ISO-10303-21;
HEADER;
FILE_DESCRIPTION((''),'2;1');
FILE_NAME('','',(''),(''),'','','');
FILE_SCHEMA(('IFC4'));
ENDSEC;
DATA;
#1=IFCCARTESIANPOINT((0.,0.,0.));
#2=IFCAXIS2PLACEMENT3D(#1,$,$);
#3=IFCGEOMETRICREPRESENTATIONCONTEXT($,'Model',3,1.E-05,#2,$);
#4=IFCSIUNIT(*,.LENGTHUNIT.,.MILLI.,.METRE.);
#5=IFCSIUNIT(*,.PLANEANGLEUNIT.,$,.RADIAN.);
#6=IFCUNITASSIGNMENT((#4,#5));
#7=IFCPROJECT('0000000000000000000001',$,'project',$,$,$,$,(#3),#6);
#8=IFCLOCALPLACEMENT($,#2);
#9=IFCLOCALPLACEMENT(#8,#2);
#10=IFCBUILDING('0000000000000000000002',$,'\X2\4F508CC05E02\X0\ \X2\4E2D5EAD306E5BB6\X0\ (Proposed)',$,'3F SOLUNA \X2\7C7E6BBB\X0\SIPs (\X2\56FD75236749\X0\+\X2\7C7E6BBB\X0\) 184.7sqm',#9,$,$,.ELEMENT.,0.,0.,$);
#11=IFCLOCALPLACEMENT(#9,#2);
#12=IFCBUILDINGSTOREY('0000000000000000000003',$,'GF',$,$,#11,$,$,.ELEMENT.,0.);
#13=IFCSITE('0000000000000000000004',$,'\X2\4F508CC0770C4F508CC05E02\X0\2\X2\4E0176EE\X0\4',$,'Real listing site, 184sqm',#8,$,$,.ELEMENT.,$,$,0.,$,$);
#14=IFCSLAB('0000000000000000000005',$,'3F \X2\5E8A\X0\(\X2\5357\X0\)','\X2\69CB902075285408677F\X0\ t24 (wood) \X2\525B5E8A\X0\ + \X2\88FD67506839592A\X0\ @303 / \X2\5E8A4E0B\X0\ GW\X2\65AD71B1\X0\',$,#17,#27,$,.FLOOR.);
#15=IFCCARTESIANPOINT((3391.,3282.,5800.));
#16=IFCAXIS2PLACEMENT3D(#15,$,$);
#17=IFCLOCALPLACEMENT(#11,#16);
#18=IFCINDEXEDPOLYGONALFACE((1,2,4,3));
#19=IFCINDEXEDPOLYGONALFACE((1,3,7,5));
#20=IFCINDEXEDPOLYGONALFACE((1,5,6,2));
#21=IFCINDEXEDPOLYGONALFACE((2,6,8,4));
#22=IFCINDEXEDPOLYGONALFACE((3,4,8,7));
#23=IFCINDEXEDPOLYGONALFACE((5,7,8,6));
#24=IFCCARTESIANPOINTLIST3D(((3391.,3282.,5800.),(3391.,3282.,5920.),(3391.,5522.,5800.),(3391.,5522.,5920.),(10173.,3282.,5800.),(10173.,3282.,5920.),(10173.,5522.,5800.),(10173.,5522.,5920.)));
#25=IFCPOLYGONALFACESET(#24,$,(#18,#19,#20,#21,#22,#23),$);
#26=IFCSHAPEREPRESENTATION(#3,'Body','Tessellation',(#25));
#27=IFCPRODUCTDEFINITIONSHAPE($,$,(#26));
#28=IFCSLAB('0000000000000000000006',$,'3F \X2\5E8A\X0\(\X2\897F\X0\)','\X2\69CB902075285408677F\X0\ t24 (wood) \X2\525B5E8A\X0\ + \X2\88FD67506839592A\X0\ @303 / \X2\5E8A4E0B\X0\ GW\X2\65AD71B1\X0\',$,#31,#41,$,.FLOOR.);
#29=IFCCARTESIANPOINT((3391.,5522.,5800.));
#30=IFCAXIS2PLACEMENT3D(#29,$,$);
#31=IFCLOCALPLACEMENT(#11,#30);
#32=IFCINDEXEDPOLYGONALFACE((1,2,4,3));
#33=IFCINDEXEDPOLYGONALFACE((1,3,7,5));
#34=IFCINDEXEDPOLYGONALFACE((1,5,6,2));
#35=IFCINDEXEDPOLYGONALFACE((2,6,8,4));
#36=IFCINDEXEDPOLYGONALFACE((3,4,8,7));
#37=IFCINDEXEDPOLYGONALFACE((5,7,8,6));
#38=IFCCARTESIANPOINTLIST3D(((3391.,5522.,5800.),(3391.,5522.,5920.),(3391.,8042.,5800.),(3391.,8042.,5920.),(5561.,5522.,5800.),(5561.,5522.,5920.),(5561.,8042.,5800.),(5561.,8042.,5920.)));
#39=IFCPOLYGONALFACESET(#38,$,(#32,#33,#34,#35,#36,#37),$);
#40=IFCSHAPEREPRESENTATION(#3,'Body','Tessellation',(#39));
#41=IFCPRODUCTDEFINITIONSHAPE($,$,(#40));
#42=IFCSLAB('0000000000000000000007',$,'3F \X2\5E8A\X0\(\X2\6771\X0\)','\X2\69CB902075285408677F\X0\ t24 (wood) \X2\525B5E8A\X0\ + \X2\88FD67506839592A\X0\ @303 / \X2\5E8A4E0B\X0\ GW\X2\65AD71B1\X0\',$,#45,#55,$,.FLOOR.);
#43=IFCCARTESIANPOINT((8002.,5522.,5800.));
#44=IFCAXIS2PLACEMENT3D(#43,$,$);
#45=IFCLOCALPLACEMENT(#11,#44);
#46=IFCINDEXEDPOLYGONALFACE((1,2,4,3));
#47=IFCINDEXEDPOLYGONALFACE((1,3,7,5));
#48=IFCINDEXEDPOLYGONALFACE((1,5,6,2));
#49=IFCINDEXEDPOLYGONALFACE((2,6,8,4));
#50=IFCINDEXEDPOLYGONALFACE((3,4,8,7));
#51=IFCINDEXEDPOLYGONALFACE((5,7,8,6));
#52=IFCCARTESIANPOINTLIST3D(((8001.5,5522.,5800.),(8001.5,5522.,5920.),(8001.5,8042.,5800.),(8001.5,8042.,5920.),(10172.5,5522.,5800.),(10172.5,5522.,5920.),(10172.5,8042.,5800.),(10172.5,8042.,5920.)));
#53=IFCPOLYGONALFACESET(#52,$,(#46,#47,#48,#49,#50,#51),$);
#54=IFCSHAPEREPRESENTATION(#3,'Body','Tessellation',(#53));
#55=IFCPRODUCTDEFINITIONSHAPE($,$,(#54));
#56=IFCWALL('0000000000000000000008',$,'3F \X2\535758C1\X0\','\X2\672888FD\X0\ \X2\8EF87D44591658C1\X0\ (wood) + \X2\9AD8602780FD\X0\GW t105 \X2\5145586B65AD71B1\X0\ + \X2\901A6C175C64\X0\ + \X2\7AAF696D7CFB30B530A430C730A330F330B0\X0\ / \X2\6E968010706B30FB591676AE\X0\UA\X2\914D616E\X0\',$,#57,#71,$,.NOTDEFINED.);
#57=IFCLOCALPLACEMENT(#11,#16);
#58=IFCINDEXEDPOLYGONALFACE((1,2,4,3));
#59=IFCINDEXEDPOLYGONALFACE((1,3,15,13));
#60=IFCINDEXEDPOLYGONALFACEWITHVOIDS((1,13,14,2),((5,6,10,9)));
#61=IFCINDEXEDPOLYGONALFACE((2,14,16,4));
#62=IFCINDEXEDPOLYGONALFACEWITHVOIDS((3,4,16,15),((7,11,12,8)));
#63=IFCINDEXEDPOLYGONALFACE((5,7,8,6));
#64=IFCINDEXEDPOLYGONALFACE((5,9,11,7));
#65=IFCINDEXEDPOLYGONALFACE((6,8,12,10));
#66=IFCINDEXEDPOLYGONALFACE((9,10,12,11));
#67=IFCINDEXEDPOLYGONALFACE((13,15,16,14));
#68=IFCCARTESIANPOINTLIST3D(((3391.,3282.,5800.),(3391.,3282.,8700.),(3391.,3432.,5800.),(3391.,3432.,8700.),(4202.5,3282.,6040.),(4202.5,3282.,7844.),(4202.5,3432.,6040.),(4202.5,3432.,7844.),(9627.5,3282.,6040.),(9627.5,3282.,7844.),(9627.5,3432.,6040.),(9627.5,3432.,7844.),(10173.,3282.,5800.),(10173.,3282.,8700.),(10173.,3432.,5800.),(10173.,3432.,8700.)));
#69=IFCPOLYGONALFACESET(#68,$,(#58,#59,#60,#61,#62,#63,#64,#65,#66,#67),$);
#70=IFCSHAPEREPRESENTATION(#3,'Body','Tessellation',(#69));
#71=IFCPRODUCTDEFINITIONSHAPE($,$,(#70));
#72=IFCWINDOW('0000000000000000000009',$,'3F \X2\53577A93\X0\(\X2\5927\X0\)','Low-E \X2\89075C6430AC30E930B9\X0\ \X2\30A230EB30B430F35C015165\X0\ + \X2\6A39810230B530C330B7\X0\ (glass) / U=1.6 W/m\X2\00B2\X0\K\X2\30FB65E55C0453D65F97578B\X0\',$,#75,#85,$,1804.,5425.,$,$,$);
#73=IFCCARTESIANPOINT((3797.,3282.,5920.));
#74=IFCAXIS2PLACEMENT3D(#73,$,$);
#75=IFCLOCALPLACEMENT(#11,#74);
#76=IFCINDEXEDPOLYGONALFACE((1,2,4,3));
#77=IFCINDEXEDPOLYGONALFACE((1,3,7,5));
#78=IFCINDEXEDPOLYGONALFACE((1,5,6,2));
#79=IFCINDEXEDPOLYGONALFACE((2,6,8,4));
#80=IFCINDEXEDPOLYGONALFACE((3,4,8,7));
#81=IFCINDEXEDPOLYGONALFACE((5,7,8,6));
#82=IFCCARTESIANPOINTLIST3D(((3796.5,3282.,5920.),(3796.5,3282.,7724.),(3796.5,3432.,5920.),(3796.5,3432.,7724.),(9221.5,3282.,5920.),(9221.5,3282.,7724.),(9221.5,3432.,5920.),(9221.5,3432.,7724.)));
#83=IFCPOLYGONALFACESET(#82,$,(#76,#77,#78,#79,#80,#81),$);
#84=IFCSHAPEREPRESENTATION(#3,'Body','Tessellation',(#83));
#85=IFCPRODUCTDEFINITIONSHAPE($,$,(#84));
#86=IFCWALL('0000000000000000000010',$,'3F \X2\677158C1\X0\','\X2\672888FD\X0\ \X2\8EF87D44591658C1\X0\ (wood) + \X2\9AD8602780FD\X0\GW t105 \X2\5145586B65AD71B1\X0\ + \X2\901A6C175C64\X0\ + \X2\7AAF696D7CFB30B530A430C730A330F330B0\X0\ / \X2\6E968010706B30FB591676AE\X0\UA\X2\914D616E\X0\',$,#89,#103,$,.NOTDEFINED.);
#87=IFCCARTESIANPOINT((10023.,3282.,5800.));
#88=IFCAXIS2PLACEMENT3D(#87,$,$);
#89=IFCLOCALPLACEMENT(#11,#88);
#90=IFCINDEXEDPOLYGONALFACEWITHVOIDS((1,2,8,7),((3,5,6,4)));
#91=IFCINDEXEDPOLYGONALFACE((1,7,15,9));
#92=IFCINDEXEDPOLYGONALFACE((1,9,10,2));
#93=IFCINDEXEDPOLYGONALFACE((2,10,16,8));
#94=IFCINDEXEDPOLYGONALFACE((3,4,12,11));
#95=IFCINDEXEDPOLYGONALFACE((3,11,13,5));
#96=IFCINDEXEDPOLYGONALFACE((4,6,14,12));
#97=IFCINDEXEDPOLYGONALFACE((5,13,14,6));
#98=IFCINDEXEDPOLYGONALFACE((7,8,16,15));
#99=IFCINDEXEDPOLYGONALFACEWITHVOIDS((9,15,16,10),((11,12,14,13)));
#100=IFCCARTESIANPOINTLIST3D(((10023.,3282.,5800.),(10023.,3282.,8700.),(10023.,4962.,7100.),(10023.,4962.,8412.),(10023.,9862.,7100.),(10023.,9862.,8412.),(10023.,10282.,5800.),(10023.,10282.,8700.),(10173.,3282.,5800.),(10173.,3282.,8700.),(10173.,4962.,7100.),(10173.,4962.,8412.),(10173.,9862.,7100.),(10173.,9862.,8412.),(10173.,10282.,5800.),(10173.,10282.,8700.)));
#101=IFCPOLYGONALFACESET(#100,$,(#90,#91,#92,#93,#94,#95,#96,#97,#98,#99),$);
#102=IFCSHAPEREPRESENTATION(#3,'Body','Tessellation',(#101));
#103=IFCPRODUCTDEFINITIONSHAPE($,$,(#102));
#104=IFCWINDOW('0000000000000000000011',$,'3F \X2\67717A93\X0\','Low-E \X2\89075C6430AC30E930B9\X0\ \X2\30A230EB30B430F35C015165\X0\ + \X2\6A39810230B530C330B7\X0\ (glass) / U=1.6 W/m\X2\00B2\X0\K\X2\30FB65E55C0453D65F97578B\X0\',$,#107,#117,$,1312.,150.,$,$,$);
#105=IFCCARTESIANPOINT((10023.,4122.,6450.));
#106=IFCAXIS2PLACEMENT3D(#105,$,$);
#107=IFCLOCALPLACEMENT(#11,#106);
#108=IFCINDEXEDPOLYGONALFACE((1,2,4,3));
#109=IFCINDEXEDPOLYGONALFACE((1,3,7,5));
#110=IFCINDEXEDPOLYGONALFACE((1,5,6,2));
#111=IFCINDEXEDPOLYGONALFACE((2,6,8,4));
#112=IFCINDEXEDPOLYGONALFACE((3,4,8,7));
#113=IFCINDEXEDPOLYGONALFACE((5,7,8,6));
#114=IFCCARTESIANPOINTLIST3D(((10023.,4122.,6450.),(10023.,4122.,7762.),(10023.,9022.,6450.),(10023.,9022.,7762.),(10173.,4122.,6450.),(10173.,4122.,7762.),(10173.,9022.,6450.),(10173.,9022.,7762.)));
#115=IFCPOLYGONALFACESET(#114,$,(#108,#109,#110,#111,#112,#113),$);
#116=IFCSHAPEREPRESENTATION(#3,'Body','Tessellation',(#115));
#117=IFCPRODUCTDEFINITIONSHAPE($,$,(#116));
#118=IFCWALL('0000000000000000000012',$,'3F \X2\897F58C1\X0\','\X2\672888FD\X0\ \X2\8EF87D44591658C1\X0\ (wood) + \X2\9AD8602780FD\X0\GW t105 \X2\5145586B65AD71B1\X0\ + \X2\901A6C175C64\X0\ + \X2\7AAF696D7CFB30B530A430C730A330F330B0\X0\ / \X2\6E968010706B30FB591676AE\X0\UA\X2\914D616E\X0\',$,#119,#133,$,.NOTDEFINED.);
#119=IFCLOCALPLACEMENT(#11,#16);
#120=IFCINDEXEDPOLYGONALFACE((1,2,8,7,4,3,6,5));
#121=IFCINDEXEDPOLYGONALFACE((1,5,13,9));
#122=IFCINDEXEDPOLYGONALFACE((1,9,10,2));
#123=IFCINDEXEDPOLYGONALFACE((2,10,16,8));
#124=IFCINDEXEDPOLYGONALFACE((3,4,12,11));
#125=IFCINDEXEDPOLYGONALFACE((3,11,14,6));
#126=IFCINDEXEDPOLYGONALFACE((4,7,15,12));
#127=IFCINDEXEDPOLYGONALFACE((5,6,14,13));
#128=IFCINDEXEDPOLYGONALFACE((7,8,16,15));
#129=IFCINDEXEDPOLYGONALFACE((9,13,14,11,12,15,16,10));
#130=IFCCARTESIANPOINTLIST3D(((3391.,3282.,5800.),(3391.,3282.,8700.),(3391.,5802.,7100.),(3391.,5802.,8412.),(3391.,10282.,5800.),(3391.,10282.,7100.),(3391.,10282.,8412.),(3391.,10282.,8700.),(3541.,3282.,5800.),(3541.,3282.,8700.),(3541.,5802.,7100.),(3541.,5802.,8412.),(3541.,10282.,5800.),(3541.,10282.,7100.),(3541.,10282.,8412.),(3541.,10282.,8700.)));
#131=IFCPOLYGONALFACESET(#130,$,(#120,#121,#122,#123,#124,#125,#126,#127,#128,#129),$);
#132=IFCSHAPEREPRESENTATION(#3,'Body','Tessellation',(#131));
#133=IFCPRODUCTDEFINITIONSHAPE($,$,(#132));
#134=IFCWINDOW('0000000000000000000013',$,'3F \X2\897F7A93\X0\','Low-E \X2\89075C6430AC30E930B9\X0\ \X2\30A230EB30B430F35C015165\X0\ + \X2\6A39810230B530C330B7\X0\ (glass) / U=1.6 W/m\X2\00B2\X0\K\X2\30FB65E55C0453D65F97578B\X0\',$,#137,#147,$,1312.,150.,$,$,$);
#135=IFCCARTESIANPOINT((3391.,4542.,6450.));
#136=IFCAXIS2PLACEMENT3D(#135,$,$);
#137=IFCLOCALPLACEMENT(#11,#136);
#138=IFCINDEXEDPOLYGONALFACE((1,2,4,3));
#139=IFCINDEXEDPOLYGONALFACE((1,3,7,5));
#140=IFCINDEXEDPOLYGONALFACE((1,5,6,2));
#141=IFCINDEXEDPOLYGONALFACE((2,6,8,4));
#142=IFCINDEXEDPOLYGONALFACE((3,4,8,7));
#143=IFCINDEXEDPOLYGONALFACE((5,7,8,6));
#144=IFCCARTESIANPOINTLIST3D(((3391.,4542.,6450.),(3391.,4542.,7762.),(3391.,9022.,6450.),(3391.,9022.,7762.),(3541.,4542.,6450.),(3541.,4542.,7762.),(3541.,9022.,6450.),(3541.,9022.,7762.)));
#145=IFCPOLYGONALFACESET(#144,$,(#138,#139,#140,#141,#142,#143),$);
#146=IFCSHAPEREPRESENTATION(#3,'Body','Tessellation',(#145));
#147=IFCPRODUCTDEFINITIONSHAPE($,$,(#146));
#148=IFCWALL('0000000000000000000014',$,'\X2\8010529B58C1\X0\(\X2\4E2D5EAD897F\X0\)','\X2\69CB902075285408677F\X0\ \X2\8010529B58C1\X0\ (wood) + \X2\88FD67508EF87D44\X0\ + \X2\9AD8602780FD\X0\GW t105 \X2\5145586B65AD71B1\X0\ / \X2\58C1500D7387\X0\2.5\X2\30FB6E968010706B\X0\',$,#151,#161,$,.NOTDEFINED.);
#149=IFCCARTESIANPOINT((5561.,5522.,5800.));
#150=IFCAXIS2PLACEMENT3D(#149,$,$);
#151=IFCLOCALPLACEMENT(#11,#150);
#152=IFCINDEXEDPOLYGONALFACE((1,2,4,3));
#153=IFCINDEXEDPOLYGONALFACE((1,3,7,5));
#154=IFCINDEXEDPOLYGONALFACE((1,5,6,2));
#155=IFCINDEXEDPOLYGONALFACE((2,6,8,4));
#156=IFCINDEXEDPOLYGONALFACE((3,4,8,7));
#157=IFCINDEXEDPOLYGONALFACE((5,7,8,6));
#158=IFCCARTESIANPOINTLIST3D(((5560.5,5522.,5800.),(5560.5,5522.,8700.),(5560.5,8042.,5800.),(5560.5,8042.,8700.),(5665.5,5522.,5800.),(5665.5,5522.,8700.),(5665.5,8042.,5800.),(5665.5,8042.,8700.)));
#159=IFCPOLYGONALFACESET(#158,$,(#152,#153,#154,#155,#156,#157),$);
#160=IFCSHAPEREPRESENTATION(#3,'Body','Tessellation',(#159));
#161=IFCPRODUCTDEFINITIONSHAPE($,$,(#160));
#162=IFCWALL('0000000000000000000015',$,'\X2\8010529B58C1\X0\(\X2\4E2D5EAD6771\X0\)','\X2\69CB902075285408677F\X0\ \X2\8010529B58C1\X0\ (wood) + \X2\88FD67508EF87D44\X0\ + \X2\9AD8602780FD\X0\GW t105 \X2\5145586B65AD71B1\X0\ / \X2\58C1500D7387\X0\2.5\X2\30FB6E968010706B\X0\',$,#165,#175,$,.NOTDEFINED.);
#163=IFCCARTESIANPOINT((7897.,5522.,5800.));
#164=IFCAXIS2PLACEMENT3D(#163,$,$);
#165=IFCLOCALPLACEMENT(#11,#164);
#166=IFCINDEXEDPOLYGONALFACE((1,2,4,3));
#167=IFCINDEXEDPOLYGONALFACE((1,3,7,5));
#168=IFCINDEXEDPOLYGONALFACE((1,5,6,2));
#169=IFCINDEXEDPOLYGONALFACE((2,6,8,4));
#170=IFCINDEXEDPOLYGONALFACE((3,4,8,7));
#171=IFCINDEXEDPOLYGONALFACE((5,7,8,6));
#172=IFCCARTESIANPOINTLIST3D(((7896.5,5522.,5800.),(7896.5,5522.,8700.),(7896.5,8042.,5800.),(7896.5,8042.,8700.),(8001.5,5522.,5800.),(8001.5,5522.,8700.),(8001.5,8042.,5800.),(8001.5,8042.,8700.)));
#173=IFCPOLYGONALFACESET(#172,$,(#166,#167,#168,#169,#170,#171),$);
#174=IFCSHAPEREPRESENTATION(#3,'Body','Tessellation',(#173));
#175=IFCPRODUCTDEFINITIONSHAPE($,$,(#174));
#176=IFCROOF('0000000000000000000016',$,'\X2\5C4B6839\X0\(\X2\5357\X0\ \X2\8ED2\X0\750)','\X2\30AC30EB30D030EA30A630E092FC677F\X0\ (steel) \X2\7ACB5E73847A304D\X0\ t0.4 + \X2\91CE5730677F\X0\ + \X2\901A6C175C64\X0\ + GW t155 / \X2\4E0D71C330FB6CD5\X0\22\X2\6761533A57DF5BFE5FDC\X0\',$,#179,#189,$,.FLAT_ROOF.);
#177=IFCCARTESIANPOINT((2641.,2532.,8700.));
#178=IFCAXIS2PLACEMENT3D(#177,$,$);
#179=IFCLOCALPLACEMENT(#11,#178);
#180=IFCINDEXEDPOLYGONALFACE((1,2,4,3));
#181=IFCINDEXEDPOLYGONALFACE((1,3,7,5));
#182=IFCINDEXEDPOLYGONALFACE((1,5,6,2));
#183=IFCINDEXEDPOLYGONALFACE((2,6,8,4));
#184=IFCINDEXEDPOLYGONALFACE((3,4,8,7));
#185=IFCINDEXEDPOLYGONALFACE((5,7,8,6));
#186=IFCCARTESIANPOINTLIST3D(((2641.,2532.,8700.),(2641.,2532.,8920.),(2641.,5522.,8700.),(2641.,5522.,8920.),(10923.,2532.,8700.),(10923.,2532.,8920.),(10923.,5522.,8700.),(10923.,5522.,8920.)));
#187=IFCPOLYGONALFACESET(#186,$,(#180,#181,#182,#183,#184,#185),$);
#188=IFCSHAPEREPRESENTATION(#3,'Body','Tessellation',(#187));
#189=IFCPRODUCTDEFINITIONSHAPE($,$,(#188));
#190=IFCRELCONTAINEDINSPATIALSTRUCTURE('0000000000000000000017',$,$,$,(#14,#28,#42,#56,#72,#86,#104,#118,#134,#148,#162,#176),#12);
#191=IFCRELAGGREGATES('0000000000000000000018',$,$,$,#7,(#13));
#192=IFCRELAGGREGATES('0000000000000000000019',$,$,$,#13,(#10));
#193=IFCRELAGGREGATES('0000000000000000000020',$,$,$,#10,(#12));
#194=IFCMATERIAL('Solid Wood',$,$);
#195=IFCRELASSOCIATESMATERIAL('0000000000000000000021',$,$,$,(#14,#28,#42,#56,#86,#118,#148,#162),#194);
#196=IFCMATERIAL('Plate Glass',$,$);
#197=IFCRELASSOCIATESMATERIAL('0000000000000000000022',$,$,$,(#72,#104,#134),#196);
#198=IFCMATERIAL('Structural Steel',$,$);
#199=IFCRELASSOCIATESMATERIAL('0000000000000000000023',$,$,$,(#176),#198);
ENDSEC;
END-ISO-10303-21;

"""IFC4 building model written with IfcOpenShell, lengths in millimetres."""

from ifc_helpers import new_model, si_unit, frame, frame_2d, origin, place, context, project, spatial, rectangle, extrude, material, element, fill, save


model = new_model("IFC4")

# Units and contexts
model_context = context("Model", 3, precision=1e-05, world=origin())
ifc_project = project(units=[si_unit("LENGTHUNIT", "METRE", prefix="MILLI"), si_unit("PLANEANGLEUNIT", "RADIAN")], contexts=[model_context])

# Site, building, storey
site_placement = place(None, origin())
site = spatial("IfcSite", under=ifc_project, at=site_placement, Name="佐賀県佐賀市2丁目4", ObjectType="Real listing site, 184sqm", CompositionType="ELEMENT", RefElevation=0.0)
building_placement = place(site_placement, origin())
building = spatial("IfcBuilding", under=site, at=building_placement, Name="佐賀市 中庭の家 (Proposed)", ObjectType="3F SOLUNA 籾殻SIPs (国産杉+籾殻) 184.7sqm", CompositionType="ELEMENT", ElevationOfRefHeight=0.0, ElevationOfTerrain=0.0)
storey_placement = place(building_placement, origin())
storey = spatial("IfcBuildingStorey", under=building, at=storey_placement, Name="GF", CompositionType="ELEMENT", Elevation=0.0)

# Slabs
ifc_material_1 = material(Name="Solid Wood")
slab_1_placement = place(storey_placement, frame((3391.0, 3282.0, 5800.0)))
element("IfcSlab", 1, at=slab_1_placement, inside=storey, material=ifc_material_1, Name="3F 床(南)", Description="構造用合板 t24 (wood) 剛床 + 製材根太 @303 / 床下 GW断熱", PredefinedType="FLOOR", context=model_context, shape_type="SweptSolid", body=[
    extrude(rectangle(XDim=6782.0, YDim=2240.0, at=frame_2d((3391.0, 1120.0))), frame((3391.0, 3282.0, 5800.0)), (0.0, 0.0, 1.0), 120.0),
])
slab_2_placement = place(storey_placement, frame((3391.0, 5522.0, 5800.0)))
element("IfcSlab", 2, at=slab_2_placement, inside=storey, material=ifc_material_1, Name="3F 床(西)", Description="構造用合板 t24 (wood) 剛床 + 製材根太 @303 / 床下 GW断熱", PredefinedType="FLOOR", context=model_context, shape_type="SweptSolid", body=[
    extrude(rectangle(XDim=2170.0, YDim=2520.0, at=frame_2d((1085.0, 1260.0))), frame((3391.0, 5522.0, 5800.0)), (0.0, 0.0, 1.0), 120.0),
])
slab_3_placement = place(storey_placement, frame((8002.0, 5522.0, 5800.0)))
element("IfcSlab", 3, at=slab_3_placement, inside=storey, material=ifc_material_1, Name="3F 床(東)", Description="構造用合板 t24 (wood) 剛床 + 製材根太 @303 / 床下 GW断熱", PredefinedType="FLOOR", context=model_context, shape_type="SweptSolid", body=[
    extrude(rectangle(XDim=2171.0, YDim=2520.0, at=frame_2d((1085.0, 1260.0))), frame((8002.0, 5522.0, 5800.0)), (0.0, 0.0, 1.0), 120.0),
])

# Walls, openings, windows
wall_1_placement = place(storey_placement, frame((3391.0, 3282.0, 5800.0)))
wall_1 = element("IfcWall", 4, at=wall_1_placement, inside=storey, material=ifc_material_1, Name="3F 南壁", Description="木製 軸組外壁 (wood) + 高性能GW t105 充填断熱 + 通気層 + 窯業系サイディング / 準耐火・外皮UA配慮", PredefinedType="NOTDEFINED", context=model_context, shape_type="SweptSolid", body=[
    extrude(rectangle(XDim=6782.0, YDim=150.0, at=frame_2d((3391.0, 75.0))), frame((3391.0, 3282.0, 5800.0)), (0.0, 0.0, 1.0), 2900.0),
])
opening_1_placement = place(storey_placement, frame((3797.0, 3282.0, 5920.0)))
opening_1 = element("IfcOpeningElement", 5, at=opening_1_placement, cuts=wall_1, PredefinedType="NOTDEFINED", context=model_context, shape_type="SweptSolid", body=[
    extrude(rectangle(XDim=5425.0, YDim=150.0, at=frame_2d((2712.0, 75.0))), frame((3797.0, 3282.0, 5920.0)), (0.0, 0.0, 1.0), 1804.0),
])
ifc_material_2 = material(Name="Plate Glass")
window_1_placement = place(storey_placement, frame((3797.0, 3282.0, 5920.0)))
window_1 = element("IfcWindow", 6, at=window_1_placement, inside=storey, material=ifc_material_2, Name="3F 南窓(大)", Description="Low-E 複層ガラス アルゴン封入 + 樹脂サッシ (glass) / U=1.6 W/m²K・日射取得型", OverallHeight=1804.0, OverallWidth=5425.0, context=model_context, shape_type="SweptSolid", body=[
    extrude(rectangle(XDim=5425.0, YDim=150.0, at=frame_2d((2712.0, 75.0))), frame((3797.0, 3282.0, 5920.0)), (0.0, 0.0, 1.0), 1804.0),
])
fill(opening_1, window_1)
wall_2_placement = place(storey_placement, frame((10023.0, 3282.0, 5800.0)))
wall_2 = element("IfcWall", 7, at=wall_2_placement, inside=storey, material=ifc_material_1, Name="3F 東壁", Description="木製 軸組外壁 (wood) + 高性能GW t105 充填断熱 + 通気層 + 窯業系サイディング / 準耐火・外皮UA配慮", PredefinedType="NOTDEFINED", context=model_context, shape_type="SweptSolid", body=[
    extrude(rectangle(XDim=150.0, YDim=7000.0, at=frame_2d((75.0, 3500.0))), frame((10023.0, 3282.0, 5800.0)), (0.0, 0.0, 1.0), 2900.0),
])
opening_2_placement = place(storey_placement, frame((10023.0, 4122.0, 6450.0)))
opening_2 = element("IfcOpeningElement", 8, at=opening_2_placement, cuts=wall_2, PredefinedType="NOTDEFINED", context=model_context, shape_type="SweptSolid", body=[
    extrude(rectangle(XDim=150.0, YDim=4900.0, at=frame_2d((75.0, 2450.0))), frame((10023.0, 4122.0, 6450.0)), (0.0, 0.0, 1.0), 1312.0),
])
window_2_placement = place(storey_placement, frame((10023.0, 4122.0, 6450.0)))
window_2 = element("IfcWindow", 9, at=window_2_placement, inside=storey, material=ifc_material_2, Name="3F 東窓", Description="Low-E 複層ガラス アルゴン封入 + 樹脂サッシ (glass) / U=1.6 W/m²K・日射取得型", OverallHeight=1312.0, OverallWidth=150.0, context=model_context, shape_type="SweptSolid", body=[
    extrude(rectangle(XDim=150.0, YDim=4900.0, at=frame_2d((75.0, 2450.0))), frame((10023.0, 4122.0, 6450.0)), (0.0, 0.0, 1.0), 1312.0),
])
fill(opening_2, window_2)
wall_3_placement = place(storey_placement, frame((3391.0, 3282.0, 5800.0)))
wall_3 = element("IfcWall", 10, at=wall_3_placement, inside=storey, material=ifc_material_1, Name="3F 西壁", Description="木製 軸組外壁 (wood) + 高性能GW t105 充填断熱 + 通気層 + 窯業系サイディング / 準耐火・外皮UA配慮", PredefinedType="NOTDEFINED", context=model_context, shape_type="SweptSolid", body=[
    extrude(rectangle(XDim=150.0, YDim=7000.0, at=frame_2d((75.0, 3500.0))), frame((3391.0, 3282.0, 5800.0)), (0.0, 0.0, 1.0), 2900.0),
])
opening_3_placement = place(storey_placement, frame((3391.0, 4542.0, 6450.0)))
opening_3 = element("IfcOpeningElement", 11, at=opening_3_placement, cuts=wall_3, PredefinedType="NOTDEFINED", context=model_context, shape_type="SweptSolid", body=[
    extrude(rectangle(XDim=150.0, YDim=4480.0, at=frame_2d((75.0, 2240.0))), frame((3391.0, 4542.0, 6450.0)), (0.0, 0.0, 1.0), 1312.0),
])
window_3_placement = place(storey_placement, frame((3391.0, 4542.0, 6450.0)))
window_3 = element("IfcWindow", 12, at=window_3_placement, inside=storey, material=ifc_material_2, Name="3F 西窓", Description="Low-E 複層ガラス アルゴン封入 + 樹脂サッシ (glass) / U=1.6 W/m²K・日射取得型", OverallHeight=1312.0, OverallWidth=150.0, context=model_context, shape_type="SweptSolid", body=[
    extrude(rectangle(XDim=150.0, YDim=4480.0, at=frame_2d((75.0, 2240.0))), frame((3391.0, 4542.0, 6450.0)), (0.0, 0.0, 1.0), 1312.0),
])
fill(opening_3, window_3)

# Walls
wall_4_placement = place(storey_placement, frame((5561.0, 5522.0, 5800.0)))
element("IfcWall", 13, at=wall_4_placement, inside=storey, material=ifc_material_1, Name="耐力壁(中庭西)", Description="構造用合板 耐力壁 (wood) + 製材軸組 + 高性能GW t105 充填断熱 / 壁倍率2.5・準耐火", PredefinedType="NOTDEFINED", context=model_context, shape_type="SweptSolid", body=[
    extrude(rectangle(XDim=105.0, YDim=2520.0, at=frame_2d((52.0, 1260.0))), frame((5561.0, 5522.0, 5800.0)), (0.0, 0.0, 1.0), 2900.0),
])
wall_5_placement = place(storey_placement, frame((7897.0, 5522.0, 5800.0)))
element("IfcWall", 14, at=wall_5_placement, inside=storey, material=ifc_material_1, Name="耐力壁(中庭東)", Description="構造用合板 耐力壁 (wood) + 製材軸組 + 高性能GW t105 充填断熱 / 壁倍率2.5・準耐火", PredefinedType="NOTDEFINED", context=model_context, shape_type="SweptSolid", body=[
    extrude(rectangle(XDim=105.0, YDim=2520.0, at=frame_2d((52.0, 1260.0))), frame((7897.0, 5522.0, 5800.0)), (0.0, 0.0, 1.0), 2900.0),
])

# Roof
ifc_material_3 = material(Name="Structural Steel")
roof_1_placement = place(storey_placement, frame((2641.0, 2532.0, 8700.0)))
element("IfcRoof", 15, at=roof_1_placement, inside=storey, material=ifc_material_3, Name="屋根(南 軒750)", Description="ガルバリウム鋼板 (steel) 立平葺き t0.4 + 野地板 + 通気層 + GW t155 / 不燃・法22条区域対応", PredefinedType="FLAT_ROOF", context=model_context, shape_type="SweptSolid", body=[
    extrude(rectangle(XDim=8282.0, YDim=2990.0, at=frame_2d((4141.0, 1495.0))), frame((2641.0, 2532.0, 8700.0)), (0.0, 0.0, 1.0), 220.0),
])

save(model, "model.ifc")
